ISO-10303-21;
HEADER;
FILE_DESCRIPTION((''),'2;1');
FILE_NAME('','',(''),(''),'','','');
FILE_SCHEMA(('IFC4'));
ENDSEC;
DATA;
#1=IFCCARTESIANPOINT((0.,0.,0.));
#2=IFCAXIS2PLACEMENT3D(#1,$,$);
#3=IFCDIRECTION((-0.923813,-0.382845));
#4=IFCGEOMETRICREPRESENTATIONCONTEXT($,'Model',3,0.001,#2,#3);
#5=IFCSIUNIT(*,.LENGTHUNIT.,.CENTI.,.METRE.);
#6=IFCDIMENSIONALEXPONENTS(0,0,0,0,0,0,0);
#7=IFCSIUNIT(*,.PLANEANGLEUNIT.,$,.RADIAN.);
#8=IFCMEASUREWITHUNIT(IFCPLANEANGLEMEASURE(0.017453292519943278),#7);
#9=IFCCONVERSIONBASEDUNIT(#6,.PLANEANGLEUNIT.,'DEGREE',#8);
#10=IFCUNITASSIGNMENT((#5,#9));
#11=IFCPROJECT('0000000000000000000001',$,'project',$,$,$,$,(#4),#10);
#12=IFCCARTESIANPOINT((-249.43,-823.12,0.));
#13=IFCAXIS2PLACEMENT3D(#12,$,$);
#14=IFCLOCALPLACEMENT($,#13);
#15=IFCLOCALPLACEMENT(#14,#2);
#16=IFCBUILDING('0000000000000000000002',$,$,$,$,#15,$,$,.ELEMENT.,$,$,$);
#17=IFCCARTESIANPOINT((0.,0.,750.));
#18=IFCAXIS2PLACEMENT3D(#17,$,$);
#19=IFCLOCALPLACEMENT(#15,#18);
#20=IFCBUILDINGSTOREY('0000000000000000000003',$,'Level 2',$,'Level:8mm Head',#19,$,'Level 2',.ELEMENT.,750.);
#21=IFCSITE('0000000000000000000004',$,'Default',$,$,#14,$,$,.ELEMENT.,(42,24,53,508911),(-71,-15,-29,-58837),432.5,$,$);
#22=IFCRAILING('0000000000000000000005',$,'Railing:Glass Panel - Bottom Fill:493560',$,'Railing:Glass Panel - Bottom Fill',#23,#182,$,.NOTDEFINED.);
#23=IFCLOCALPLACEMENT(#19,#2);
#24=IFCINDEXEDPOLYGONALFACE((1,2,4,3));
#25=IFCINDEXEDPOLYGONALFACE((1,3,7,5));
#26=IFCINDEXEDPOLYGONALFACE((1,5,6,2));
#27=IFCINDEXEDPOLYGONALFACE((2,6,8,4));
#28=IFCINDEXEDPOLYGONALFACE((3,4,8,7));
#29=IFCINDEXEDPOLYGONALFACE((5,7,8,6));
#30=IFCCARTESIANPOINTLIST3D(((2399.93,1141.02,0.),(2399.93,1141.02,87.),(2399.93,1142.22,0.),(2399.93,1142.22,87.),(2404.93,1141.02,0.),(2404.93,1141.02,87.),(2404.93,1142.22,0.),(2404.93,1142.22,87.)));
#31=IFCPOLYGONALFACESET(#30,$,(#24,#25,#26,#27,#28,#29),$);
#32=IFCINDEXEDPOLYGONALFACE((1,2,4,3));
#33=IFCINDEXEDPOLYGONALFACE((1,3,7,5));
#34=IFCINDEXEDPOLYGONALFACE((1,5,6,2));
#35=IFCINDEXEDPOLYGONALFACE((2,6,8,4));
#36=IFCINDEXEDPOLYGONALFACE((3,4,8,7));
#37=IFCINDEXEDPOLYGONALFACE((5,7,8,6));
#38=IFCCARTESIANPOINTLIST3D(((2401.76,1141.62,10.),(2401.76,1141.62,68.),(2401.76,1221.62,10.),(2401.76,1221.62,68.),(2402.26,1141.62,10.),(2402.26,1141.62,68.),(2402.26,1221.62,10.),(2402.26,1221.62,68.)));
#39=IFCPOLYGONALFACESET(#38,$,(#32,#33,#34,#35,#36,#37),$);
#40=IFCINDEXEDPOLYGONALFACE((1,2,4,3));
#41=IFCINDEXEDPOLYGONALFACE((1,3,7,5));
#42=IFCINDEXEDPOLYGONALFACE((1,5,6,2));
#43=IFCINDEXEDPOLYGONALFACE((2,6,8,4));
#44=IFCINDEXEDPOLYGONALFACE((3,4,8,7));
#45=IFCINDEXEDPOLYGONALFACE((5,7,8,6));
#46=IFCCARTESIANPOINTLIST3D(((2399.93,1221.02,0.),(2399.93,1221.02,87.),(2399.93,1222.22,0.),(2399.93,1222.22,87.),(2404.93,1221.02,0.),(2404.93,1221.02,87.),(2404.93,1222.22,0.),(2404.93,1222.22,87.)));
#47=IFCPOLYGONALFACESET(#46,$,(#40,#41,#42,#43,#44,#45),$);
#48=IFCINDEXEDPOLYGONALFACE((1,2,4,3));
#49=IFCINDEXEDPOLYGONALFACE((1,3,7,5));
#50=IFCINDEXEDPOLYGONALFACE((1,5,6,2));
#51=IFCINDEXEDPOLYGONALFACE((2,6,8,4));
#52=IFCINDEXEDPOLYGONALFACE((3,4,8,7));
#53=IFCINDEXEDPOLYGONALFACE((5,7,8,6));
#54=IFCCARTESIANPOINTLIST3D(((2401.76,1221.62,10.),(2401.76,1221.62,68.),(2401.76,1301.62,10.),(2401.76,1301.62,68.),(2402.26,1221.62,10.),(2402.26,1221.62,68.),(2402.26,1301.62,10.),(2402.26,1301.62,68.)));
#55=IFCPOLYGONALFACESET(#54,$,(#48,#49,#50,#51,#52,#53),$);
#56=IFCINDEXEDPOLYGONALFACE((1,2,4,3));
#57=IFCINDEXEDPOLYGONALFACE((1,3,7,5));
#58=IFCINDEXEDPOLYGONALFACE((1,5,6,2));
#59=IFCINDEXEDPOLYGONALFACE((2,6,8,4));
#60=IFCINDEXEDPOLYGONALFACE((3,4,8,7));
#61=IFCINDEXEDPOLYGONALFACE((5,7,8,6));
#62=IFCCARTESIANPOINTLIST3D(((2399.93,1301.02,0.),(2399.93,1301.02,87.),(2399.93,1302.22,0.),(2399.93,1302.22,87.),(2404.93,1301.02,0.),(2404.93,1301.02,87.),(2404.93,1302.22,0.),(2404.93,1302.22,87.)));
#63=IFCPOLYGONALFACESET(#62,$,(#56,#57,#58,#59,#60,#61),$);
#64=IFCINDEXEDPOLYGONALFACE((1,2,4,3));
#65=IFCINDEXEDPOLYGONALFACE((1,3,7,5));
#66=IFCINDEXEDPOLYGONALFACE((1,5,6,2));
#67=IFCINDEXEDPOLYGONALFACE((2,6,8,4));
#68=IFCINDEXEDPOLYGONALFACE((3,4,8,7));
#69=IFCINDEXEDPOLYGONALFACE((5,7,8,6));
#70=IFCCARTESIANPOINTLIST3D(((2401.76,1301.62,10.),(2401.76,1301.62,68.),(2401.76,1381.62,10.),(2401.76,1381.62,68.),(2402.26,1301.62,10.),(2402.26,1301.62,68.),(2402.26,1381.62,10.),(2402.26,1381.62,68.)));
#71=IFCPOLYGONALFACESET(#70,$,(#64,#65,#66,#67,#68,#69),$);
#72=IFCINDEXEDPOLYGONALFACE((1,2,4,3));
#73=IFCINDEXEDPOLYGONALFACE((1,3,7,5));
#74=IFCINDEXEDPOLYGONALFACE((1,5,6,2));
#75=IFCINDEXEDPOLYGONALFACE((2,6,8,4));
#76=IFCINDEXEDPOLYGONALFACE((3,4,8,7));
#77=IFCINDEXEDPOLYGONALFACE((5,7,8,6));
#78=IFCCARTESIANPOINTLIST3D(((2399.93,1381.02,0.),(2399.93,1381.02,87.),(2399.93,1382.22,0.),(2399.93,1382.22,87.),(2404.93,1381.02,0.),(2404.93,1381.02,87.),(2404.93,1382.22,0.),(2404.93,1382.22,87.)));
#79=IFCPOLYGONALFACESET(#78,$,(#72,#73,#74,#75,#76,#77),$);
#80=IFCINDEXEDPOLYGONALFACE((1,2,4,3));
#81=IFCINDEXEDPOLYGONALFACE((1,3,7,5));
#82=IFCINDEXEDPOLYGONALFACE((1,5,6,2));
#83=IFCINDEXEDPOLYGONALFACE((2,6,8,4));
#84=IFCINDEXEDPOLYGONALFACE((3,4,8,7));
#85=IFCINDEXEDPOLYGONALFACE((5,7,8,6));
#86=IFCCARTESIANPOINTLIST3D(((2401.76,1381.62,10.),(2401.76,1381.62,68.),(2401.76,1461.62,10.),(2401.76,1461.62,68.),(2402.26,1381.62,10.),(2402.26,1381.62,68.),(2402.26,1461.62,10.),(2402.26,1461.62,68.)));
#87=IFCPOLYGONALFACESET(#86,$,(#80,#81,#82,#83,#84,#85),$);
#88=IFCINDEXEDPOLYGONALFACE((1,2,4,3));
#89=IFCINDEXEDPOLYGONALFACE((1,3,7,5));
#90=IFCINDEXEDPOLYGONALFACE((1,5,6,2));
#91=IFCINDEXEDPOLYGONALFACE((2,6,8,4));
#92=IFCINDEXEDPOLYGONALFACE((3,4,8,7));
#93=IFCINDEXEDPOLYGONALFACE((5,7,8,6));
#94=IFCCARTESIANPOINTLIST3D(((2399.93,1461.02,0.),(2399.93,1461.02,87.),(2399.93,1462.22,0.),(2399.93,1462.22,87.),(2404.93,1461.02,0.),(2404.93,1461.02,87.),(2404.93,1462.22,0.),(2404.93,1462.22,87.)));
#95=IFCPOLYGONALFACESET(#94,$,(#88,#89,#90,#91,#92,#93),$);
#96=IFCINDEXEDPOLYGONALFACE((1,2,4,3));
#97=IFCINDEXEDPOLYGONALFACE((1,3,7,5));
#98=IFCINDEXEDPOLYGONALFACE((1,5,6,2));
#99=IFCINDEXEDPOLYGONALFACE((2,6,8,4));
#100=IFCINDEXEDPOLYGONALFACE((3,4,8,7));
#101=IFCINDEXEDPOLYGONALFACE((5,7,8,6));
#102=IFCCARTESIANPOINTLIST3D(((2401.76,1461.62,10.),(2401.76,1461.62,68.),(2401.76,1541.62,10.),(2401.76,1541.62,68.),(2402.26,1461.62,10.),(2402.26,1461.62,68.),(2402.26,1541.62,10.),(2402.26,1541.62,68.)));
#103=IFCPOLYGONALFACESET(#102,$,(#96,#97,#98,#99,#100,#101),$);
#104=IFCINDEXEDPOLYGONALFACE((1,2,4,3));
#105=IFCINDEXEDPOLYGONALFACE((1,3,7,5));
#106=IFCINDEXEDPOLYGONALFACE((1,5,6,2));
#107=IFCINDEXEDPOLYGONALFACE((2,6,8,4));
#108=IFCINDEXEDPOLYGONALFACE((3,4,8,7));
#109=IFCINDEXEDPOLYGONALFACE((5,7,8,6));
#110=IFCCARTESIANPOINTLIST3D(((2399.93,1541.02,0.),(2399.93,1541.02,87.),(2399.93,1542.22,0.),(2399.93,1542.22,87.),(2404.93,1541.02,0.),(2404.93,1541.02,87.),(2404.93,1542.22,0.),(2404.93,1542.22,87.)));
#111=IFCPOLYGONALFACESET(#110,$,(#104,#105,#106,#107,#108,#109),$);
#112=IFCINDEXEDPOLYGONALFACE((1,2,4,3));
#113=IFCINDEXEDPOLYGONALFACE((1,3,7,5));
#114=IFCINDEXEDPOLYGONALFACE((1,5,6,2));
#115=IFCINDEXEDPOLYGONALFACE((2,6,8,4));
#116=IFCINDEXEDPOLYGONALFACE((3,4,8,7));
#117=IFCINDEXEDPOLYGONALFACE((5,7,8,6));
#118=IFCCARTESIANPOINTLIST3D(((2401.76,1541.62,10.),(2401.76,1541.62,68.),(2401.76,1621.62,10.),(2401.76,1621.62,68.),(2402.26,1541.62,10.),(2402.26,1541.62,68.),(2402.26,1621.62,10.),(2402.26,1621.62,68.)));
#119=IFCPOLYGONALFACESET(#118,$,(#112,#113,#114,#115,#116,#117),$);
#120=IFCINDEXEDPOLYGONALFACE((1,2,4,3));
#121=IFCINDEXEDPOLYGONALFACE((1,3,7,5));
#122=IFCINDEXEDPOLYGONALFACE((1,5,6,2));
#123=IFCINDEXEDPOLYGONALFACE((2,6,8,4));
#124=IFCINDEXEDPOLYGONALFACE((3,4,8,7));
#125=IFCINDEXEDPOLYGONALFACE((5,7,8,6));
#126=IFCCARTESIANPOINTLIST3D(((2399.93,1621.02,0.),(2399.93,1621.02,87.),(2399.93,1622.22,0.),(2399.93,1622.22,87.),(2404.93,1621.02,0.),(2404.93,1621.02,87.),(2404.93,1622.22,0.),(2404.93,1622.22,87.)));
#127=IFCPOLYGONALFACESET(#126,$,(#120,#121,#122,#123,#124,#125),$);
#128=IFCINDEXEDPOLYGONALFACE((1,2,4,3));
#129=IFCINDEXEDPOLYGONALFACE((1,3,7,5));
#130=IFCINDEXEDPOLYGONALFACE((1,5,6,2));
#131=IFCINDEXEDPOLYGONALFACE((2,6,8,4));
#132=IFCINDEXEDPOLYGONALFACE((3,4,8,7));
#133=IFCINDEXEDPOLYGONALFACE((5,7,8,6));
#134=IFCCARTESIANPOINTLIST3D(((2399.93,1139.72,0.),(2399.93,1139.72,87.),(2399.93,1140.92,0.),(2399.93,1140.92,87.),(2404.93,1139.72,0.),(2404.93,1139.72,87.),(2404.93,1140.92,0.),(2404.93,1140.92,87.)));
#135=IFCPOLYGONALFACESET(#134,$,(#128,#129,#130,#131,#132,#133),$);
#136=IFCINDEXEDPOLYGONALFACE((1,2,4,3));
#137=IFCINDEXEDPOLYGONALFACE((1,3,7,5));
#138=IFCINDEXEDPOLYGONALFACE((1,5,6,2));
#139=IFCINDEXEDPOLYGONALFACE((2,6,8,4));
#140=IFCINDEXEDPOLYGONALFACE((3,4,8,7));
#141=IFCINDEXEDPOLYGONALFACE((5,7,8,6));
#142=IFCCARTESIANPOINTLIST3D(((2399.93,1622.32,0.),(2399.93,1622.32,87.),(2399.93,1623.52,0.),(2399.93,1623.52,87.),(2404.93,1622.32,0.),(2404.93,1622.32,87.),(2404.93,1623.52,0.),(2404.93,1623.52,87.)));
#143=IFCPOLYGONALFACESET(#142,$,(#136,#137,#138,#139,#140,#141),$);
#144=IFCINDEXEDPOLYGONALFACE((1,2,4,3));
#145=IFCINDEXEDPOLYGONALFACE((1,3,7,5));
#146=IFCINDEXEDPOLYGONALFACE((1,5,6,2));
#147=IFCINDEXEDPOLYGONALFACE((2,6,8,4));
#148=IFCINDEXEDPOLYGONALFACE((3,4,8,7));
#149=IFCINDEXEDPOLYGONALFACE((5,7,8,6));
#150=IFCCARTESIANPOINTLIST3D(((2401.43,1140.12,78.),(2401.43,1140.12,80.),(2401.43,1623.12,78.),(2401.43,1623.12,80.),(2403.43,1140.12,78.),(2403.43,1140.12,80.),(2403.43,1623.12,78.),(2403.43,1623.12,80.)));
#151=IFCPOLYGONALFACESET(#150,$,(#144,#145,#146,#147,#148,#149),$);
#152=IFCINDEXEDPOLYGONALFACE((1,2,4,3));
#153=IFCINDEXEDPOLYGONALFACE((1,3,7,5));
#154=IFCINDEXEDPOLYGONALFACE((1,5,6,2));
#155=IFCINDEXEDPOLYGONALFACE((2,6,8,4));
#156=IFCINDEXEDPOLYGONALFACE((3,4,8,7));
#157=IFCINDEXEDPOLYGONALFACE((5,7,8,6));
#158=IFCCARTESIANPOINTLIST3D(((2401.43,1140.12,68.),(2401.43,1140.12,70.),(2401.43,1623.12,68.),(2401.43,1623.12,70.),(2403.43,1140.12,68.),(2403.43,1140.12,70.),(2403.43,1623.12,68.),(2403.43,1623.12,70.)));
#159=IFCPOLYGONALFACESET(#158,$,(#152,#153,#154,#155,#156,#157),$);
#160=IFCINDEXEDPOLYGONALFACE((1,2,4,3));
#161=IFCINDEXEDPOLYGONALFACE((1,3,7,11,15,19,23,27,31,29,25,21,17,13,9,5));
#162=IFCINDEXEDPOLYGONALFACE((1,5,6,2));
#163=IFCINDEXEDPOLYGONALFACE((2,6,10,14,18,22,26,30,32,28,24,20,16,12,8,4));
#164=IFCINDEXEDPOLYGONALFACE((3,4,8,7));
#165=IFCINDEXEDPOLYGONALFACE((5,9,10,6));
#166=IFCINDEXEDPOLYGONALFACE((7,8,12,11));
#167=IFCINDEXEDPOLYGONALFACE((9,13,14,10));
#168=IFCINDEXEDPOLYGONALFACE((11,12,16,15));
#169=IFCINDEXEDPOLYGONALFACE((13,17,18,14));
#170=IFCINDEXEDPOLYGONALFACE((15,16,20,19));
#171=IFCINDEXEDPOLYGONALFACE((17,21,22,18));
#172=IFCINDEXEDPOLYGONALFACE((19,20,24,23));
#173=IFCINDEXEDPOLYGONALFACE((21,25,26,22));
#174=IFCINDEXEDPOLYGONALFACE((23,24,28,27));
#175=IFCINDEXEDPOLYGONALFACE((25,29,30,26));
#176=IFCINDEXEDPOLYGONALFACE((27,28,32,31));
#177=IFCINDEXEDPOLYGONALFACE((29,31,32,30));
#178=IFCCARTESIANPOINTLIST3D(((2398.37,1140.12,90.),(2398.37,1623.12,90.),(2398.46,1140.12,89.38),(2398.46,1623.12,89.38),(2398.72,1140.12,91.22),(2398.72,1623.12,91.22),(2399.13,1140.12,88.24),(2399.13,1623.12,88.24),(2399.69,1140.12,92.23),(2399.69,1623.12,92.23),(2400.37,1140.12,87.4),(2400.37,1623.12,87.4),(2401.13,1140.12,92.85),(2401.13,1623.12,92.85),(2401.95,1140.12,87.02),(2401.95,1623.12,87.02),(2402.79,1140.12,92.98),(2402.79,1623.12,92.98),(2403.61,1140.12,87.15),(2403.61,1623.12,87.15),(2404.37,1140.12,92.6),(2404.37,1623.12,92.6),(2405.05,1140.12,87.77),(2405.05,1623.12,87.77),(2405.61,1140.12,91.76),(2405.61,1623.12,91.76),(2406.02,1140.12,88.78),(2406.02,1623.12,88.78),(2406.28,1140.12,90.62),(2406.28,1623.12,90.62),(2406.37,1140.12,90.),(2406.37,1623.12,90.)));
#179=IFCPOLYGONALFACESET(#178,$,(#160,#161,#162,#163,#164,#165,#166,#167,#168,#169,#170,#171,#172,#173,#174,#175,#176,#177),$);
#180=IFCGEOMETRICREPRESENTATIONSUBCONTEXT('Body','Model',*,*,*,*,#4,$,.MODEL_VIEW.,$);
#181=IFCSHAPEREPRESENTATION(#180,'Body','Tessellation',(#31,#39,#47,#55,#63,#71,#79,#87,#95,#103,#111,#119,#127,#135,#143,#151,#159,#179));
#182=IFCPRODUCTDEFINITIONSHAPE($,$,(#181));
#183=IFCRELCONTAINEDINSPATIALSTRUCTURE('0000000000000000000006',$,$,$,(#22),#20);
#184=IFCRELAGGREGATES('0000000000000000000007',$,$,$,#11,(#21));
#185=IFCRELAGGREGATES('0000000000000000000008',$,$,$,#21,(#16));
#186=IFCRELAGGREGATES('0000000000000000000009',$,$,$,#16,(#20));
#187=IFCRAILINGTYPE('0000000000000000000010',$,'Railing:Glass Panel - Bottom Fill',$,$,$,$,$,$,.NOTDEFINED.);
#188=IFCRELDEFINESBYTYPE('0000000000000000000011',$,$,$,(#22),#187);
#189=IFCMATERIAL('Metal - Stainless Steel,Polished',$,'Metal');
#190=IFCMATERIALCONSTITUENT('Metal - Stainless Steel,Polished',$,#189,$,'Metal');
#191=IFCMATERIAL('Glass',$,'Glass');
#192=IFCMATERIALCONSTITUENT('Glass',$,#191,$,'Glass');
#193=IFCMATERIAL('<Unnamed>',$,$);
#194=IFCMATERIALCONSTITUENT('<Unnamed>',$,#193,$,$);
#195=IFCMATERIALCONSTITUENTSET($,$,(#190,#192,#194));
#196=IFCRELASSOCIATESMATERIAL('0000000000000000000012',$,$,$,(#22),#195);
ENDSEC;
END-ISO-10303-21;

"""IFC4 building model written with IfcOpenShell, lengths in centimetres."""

from ifc_helpers import new_model, entity, si_unit, converted_unit, direction, frame, origin, place, context, subcontext, project, spatial, indexed_curve, outline, extrude, material, constituent, constituent_set, type_object, element, save


model = new_model("IFC4")

# Units and contexts
model_context = context("Model", 3, precision=0.001, world=origin(), true_north=direction((-0.923813, -0.382845)))
body_context = subcontext(model_context, "Body", "Model", "MODEL_VIEW")
ifc_project = project(units=[si_unit("LENGTHUNIT", "METRE", prefix="CENTI"), converted_unit("PLANEANGLEUNIT", "DEGREE", entity("IfcPlaneAngleMeasure", 0.017453292519943278), si_unit("PLANEANGLEUNIT", "RADIAN"), dimensions=[0, 0, 0, 0, 0, 0, 0])], contexts=[model_context])

# Site, building, storey
site_placement = place(None, frame((-249.43, -823.12, 0.0)))
site = spatial("IfcSite", under=ifc_project, at=site_placement, Name="Default", CompositionType="ELEMENT", RefLatitude=(42, 24, 53, 508911), RefLongitude=(-71, -15, -29, -58837), RefElevation=432.5)
building_placement = place(site_placement, origin())
building = spatial("IfcBuilding", under=site, at=building_placement, CompositionType="ELEMENT")
storey_placement = place(building_placement, frame((0.0, 0.0, 750.0)))
storey = spatial("IfcBuildingStorey", under=building, at=storey_placement, Name="Level 2", ObjectType="Level:8mm Head", LongName="Level 2", CompositionType="ELEMENT", Elevation=750.0)

# Railing
ifc_material_1 = material(Name="Metal - Stainless Steel,Polished", Category="Metal")
ifc_constituent_1 = constituent(ifc_material_1, Name="Metal - Stainless Steel,Polished", Category="Metal")
ifc_material_2 = material(Name="Glass", Category="Glass")
ifc_constituent_2 = constituent(ifc_material_2, Name="Glass", Category="Glass")
ifc_material_3 = material(Name="<Unnamed>")
ifc_constituent_3 = constituent(ifc_material_3, Name="<Unnamed>")
ifc_constituent_set = constituent_set(constituents=[ifc_constituent_1, ifc_constituent_2, ifc_constituent_3])
railing_type = type_object("IfcRailingType", Name="Railing:Glass Panel - Bottom Fill", PredefinedType="NOTDEFINED")
railing_placement = place(storey_placement, origin())
element("IfcRailing", 1, at=railing_placement, inside=storey, type_object=railing_type, material=ifc_constituent_set, Name="Railing:Glass Panel - Bottom Fill:493560", ObjectType="Railing:Glass Panel - Bottom Fill", PredefinedType="NOTDEFINED", context=body_context, shape_type="SweptSolid", body=[
    extrude(outline(indexed_curve([(-2.5, -0.6), (2.5, -0.6), (2.5, 0.6), (-2.5, 0.6), (-2.5, -0.6)], self_intersect=False)), frame((2402.43, 1141.62, 0.0), z_axis=(0.0, 0.0, 1.0), x_axis=(-1.0, 0.0, 0.0)), (0.0, 0.0, 1.0), 87.0),
    extrude(outline(indexed_curve([(-0.25, -40.0), (0.25, -40.0), (0.25, 40.0), (-0.25, 40.0), (-0.25, -40.0)], self_intersect=False)), frame((2402.01, 1181.62, 10.0), z_axis=(0.0, 0.0, 1.0), x_axis=(-1.0, 0.0, 0.0)), (0.0, 0.0, 1.0), 58.0),
    extrude(outline(indexed_curve([(-2.5, -0.6), (2.5, -0.6), (2.5, 0.6), (-2.5, 0.6), (-2.5, -0.6)], self_intersect=False)), frame((2402.43, 1221.62, 0.0), z_axis=(0.0, 0.0, 1.0), x_axis=(-1.0, 0.0, 0.0)), (0.0, 0.0, 1.0), 87.0),
    extrude(outline(indexed_curve([(-0.25, -40.0), (0.25, -40.0), (0.25, 40.0), (-0.25, 40.0), (-0.25, -40.0)], self_intersect=False)), frame((2402.01, 1261.62, 10.0), z_axis=(0.0, 0.0, 1.0), x_axis=(-1.0, 0.0, 0.0)), (0.0, 0.0, 1.0), 58.0),
    extrude(outline(indexed_curve([(-2.5, -0.6), (2.5, -0.6), (2.5, 0.6), (-2.5, 0.6), (-2.5, -0.6)], self_intersect=False)), frame((2402.43, 1301.62, 0.0), z_axis=(0.0, 0.0, 1.0), x_axis=(-1.0, 0.0, 0.0)), (0.0, 0.0, 1.0), 87.0),
    extrude(outline(indexed_curve([(-0.25, -40.0), (0.25, -40.0), (0.25, 40.0), (-0.25, 40.0), (-0.25, -40.0)], self_intersect=False)), frame((2402.01, 1341.62, 10.0), z_axis=(0.0, 0.0, 1.0), x_axis=(-1.0, 0.0, 0.0)), (0.0, 0.0, 1.0), 58.0),
    extrude(outline(indexed_curve([(-2.5, -0.6), (2.5, -0.6), (2.5, 0.6), (-2.5, 0.6), (-2.5, -0.6)], self_intersect=False)), frame((2402.43, 1381.62, 0.0), z_axis=(0.0, 0.0, 1.0), x_axis=(-1.0, 0.0, 0.0)), (0.0, 0.0, 1.0), 87.0),
    extrude(outline(indexed_curve([(-0.25, -40.0), (0.25, -40.0), (0.25, 40.0), (-0.25, 40.0), (-0.25, -40.0)], self_intersect=False)), frame((2402.01, 1421.62, 10.0), z_axis=(0.0, 0.0, 1.0), x_axis=(-1.0, 0.0, 0.0)), (0.0, 0.0, 1.0), 58.0),
    extrude(outline(indexed_curve([(-2.5, -0.6), (2.5, -0.6), (2.5, 0.6), (-2.5, 0.6), (-2.5, -0.6)], self_intersect=False)), frame((2402.43, 1461.62, 0.0), z_axis=(0.0, 0.0, 1.0), x_axis=(-1.0, 0.0, 0.0)), (0.0, 0.0, 1.0), 87.0),
    extrude(outline(indexed_curve([(-0.25, -40.0), (0.25, -40.0), (0.25, 40.0), (-0.25, 40.0), (-0.25, -40.0)], self_intersect=False)), frame((2402.01, 1501.62, 10.0), z_axis=(0.0, 0.0, 1.0), x_axis=(-1.0, 0.0, 0.0)), (0.0, 0.0, 1.0), 58.0),
    extrude(outline(indexed_curve([(-2.5, -0.6), (2.5, -0.6), (2.5, 0.6), (-2.5, 0.6), (-2.5, -0.6)], self_intersect=False)), frame((2402.43, 1541.62, 0.0), z_axis=(0.0, 0.0, 1.0), x_axis=(-1.0, 0.0, 0.0)), (0.0, 0.0, 1.0), 87.0),
    extrude(outline(indexed_curve([(-0.25, -40.0), (0.25, -40.0), (0.25, 40.0), (-0.25, 40.0), (-0.25, -40.0)], self_intersect=False)), frame((2402.01, 1581.62, 10.0), z_axis=(0.0, 0.0, 1.0), x_axis=(-1.0, 0.0, 0.0)), (0.0, 0.0, 1.0), 58.0),
    extrude(outline(indexed_curve([(-2.5, -0.6), (2.5, -0.6), (2.5, 0.6), (-2.5, 0.6), (-2.5, -0.6)], self_intersect=False)), frame((2402.43, 1621.62, 0.0), z_axis=(0.0, 0.0, 1.0), x_axis=(-1.0, 0.0, 0.0)), (0.0, 0.0, 1.0), 87.0),
    extrude(outline(indexed_curve([(-2.5, -0.6), (2.5, -0.6), (2.5, 0.6), (-2.5, 0.6), (-2.5, -0.6)], self_intersect=False)), frame((2402.43, 1140.32, 0.0), z_axis=(0.0, 0.0, 1.0), x_axis=(-1.0, 0.0, 0.0)), (0.0, 0.0, 1.0), 87.0),
    extrude(outline(indexed_curve([(-2.5, -0.6), (2.5, -0.6), (2.5, 0.6), (-2.5, 0.6), (-2.5, -0.6)], self_intersect=False)), frame((2402.43, 1622.92, 0.0), z_axis=(0.0, 0.0, 1.0), x_axis=(-1.0, 0.0, 0.0)), (0.0, 0.0, 1.0), 87.0),
    extrude(outline(indexed_curve([(-241.5, -1.0), (241.5, -1.0), (241.5, 1.0), (-241.5, 1.0), (-241.5, -1.0)], self_intersect=False)), frame((2402.43, 1381.62, 78.0), z_axis=(0.0, 0.0, 1.0), x_axis=(0.0, -1.0, 0.0)), (0.0, 0.0, 1.0), 2.0),
    extrude(outline(indexed_curve([(-241.5, -1.0), (241.5, -1.0), (241.5, 1.0), (-241.5, 1.0), (-241.5, -1.0)], self_intersect=False)), frame((2402.43, 1381.62, 68.0), z_axis=(0.0, 0.0, 1.0), x_axis=(0.0, -1.0, 0.0)), (0.0, 0.0, 1.0), 2.0),
    extrude(outline(indexed_curve([(-1.09, -3.85), (0.18, -3.85), (1.42, -3.18), (2.41, -1.97), (2.98, -0.41), (3.04, 1.22), (2.58, 2.63), (1.67, 3.59), (1.09, 3.85), (-0.18, 3.85), (-1.42, 3.18), (-2.41, 1.97), (-2.98, 0.41), (-3.04, -1.22), (-2.58, -2.63), (-1.67, -3.59), (-1.09, -3.85)], self_intersect=False)), frame((2402.37, 1140.12, 90.0), z_axis=(0.0, 1.0, 0.0), x_axis=(-0.27267, 0.0, -0.962108)), (0.0, 0.0, 1.0), 483.0),
])

save(model, "model.ifc")
